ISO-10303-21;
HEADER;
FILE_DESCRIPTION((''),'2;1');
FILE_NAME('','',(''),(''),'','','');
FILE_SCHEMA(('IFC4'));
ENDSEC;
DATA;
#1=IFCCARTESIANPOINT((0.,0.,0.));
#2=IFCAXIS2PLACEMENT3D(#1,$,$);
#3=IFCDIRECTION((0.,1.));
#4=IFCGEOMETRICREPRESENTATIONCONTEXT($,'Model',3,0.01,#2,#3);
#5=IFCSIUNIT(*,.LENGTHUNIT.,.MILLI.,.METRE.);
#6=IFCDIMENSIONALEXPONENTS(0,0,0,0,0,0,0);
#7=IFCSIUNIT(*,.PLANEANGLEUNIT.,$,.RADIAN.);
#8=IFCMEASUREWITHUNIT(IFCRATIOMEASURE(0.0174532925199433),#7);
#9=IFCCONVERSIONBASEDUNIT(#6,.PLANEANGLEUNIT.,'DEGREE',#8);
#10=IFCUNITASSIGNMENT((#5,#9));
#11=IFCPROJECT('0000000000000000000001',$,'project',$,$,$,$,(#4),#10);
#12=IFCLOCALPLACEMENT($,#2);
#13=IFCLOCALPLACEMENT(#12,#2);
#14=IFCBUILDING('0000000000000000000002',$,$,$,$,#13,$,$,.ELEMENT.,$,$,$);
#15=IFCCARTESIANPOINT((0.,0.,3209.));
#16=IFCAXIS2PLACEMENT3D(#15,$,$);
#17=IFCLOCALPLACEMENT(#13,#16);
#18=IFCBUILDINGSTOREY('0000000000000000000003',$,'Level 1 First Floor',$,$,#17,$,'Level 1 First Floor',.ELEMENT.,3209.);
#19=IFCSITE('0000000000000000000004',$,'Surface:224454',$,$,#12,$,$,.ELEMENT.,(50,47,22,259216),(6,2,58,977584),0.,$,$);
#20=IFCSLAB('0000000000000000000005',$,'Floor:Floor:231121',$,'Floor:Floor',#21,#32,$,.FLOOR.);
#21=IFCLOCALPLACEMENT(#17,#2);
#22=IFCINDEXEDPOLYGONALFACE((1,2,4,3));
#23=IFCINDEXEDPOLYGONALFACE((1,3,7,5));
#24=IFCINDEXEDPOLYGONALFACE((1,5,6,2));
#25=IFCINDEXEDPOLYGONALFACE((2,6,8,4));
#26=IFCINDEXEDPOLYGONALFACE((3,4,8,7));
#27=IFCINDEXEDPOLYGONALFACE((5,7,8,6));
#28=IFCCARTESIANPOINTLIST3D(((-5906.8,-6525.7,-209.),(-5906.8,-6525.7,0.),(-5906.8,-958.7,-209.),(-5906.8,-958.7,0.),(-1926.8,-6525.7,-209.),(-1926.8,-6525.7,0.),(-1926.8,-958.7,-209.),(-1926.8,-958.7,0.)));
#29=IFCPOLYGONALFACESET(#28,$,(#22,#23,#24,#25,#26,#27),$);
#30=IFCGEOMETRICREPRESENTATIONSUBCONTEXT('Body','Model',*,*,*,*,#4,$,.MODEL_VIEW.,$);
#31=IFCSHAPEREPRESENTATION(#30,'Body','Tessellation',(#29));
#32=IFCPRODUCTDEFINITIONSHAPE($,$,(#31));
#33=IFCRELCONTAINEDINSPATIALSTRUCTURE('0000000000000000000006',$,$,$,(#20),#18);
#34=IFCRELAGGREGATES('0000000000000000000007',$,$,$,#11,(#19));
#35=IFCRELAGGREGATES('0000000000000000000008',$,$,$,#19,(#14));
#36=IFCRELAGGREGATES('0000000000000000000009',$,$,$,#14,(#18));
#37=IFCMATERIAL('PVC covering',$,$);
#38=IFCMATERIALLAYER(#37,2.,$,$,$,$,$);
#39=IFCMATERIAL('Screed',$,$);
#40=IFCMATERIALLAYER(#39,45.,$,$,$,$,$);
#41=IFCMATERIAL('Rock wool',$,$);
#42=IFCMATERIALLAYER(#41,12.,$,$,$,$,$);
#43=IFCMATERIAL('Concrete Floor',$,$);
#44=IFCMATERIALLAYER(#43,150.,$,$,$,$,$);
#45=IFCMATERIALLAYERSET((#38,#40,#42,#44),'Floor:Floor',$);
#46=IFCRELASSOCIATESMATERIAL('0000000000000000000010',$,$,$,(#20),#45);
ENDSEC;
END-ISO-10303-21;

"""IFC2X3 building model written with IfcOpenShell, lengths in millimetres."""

from ifc_helpers import new_model, entity, si_unit, converted_unit, direction, frame, frame_2d, origin, place, context, subcontext, project, spatial, rectangle, extrude, material, layer, layer_set, layer_usage, element, save


model = new_model("IFC2X3")

# Units and contexts
model_context = context("Model", 3, precision=0.01, world=origin(), true_north=direction((0.0, 1.0)))
body_context = subcontext(model_context, "Body", "Model", "MODEL_VIEW")
ifc_project = project(units=[si_unit("LENGTHUNIT", "METRE", prefix="MILLI"), converted_unit("PLANEANGLEUNIT", "DEGREE", entity("IfcRatioMeasure", 0.0174532925199433), si_unit("PLANEANGLEUNIT", "RADIAN"), dimensions=[0, 0, 0, 0, 0, 0, 0])], contexts=[model_context])

# Site, building, storey
site_placement = place(None, origin())
site = spatial("IfcSite", under=ifc_project, at=site_placement, Name="Surface:224454", CompositionType="ELEMENT", RefLatitude=(50, 47, 22, 259216), RefLongitude=(6, 2, 58, 977584), RefElevation=0.0)
building_placement = place(site_placement, origin())
building = spatial("IfcBuilding", under=site, at=building_placement, CompositionType="ELEMENT")
storey_placement = place(building_placement, frame((0.0, 0.0, 3209.0)))
storey = spatial("IfcBuildingStorey", under=building, at=storey_placement, Name="Level 1 First Floor", LongName="Level 1 First Floor", CompositionType="ELEMENT", Elevation=3209.0)

# Slab
ifc_material_1 = material(Name="PVC covering")
ifc_layer_1 = layer(ifc_material_1, 2.0)
ifc_material_2 = material(Name="Screed")
ifc_layer_2 = layer(ifc_material_2, 45.0)
ifc_material_3 = material(Name="Rock wool")
ifc_layer_3 = layer(ifc_material_3, 12.0)
ifc_material_4 = material(Name="Concrete Floor")
ifc_layer_4 = layer(ifc_material_4, 150.0)
ifc_layer_set = layer_set([ifc_layer_1, ifc_layer_2, ifc_layer_3, ifc_layer_4], Name="Floor:Floor")
ifc_layer_usage = layer_usage(ifc_layer_set, "AXIS3", "POSITIVE", 0.0)
slab_placement = place(storey_placement, origin())
element("IfcSlab", 1, at=slab_placement, inside=storey, material=ifc_layer_usage, Name="Floor:Floor:231121", ObjectType="Floor:Floor", PredefinedType="FLOOR", context=body_context, shape_type="SweptSolid", body=[
    extrude(rectangle(XDim=5567.0, YDim=3980.0, at=frame_2d((0.0, 0.0), x_axis=(1.0, 0.0))), frame((-3916.8, -3742.2, 0.0), z_axis=(0.0, 0.0, -1.0), x_axis=(0.0, 1.0, 0.0)), (0.0, 0.0, 1.0), 209.0),
])

save(model, "model.ifc")
